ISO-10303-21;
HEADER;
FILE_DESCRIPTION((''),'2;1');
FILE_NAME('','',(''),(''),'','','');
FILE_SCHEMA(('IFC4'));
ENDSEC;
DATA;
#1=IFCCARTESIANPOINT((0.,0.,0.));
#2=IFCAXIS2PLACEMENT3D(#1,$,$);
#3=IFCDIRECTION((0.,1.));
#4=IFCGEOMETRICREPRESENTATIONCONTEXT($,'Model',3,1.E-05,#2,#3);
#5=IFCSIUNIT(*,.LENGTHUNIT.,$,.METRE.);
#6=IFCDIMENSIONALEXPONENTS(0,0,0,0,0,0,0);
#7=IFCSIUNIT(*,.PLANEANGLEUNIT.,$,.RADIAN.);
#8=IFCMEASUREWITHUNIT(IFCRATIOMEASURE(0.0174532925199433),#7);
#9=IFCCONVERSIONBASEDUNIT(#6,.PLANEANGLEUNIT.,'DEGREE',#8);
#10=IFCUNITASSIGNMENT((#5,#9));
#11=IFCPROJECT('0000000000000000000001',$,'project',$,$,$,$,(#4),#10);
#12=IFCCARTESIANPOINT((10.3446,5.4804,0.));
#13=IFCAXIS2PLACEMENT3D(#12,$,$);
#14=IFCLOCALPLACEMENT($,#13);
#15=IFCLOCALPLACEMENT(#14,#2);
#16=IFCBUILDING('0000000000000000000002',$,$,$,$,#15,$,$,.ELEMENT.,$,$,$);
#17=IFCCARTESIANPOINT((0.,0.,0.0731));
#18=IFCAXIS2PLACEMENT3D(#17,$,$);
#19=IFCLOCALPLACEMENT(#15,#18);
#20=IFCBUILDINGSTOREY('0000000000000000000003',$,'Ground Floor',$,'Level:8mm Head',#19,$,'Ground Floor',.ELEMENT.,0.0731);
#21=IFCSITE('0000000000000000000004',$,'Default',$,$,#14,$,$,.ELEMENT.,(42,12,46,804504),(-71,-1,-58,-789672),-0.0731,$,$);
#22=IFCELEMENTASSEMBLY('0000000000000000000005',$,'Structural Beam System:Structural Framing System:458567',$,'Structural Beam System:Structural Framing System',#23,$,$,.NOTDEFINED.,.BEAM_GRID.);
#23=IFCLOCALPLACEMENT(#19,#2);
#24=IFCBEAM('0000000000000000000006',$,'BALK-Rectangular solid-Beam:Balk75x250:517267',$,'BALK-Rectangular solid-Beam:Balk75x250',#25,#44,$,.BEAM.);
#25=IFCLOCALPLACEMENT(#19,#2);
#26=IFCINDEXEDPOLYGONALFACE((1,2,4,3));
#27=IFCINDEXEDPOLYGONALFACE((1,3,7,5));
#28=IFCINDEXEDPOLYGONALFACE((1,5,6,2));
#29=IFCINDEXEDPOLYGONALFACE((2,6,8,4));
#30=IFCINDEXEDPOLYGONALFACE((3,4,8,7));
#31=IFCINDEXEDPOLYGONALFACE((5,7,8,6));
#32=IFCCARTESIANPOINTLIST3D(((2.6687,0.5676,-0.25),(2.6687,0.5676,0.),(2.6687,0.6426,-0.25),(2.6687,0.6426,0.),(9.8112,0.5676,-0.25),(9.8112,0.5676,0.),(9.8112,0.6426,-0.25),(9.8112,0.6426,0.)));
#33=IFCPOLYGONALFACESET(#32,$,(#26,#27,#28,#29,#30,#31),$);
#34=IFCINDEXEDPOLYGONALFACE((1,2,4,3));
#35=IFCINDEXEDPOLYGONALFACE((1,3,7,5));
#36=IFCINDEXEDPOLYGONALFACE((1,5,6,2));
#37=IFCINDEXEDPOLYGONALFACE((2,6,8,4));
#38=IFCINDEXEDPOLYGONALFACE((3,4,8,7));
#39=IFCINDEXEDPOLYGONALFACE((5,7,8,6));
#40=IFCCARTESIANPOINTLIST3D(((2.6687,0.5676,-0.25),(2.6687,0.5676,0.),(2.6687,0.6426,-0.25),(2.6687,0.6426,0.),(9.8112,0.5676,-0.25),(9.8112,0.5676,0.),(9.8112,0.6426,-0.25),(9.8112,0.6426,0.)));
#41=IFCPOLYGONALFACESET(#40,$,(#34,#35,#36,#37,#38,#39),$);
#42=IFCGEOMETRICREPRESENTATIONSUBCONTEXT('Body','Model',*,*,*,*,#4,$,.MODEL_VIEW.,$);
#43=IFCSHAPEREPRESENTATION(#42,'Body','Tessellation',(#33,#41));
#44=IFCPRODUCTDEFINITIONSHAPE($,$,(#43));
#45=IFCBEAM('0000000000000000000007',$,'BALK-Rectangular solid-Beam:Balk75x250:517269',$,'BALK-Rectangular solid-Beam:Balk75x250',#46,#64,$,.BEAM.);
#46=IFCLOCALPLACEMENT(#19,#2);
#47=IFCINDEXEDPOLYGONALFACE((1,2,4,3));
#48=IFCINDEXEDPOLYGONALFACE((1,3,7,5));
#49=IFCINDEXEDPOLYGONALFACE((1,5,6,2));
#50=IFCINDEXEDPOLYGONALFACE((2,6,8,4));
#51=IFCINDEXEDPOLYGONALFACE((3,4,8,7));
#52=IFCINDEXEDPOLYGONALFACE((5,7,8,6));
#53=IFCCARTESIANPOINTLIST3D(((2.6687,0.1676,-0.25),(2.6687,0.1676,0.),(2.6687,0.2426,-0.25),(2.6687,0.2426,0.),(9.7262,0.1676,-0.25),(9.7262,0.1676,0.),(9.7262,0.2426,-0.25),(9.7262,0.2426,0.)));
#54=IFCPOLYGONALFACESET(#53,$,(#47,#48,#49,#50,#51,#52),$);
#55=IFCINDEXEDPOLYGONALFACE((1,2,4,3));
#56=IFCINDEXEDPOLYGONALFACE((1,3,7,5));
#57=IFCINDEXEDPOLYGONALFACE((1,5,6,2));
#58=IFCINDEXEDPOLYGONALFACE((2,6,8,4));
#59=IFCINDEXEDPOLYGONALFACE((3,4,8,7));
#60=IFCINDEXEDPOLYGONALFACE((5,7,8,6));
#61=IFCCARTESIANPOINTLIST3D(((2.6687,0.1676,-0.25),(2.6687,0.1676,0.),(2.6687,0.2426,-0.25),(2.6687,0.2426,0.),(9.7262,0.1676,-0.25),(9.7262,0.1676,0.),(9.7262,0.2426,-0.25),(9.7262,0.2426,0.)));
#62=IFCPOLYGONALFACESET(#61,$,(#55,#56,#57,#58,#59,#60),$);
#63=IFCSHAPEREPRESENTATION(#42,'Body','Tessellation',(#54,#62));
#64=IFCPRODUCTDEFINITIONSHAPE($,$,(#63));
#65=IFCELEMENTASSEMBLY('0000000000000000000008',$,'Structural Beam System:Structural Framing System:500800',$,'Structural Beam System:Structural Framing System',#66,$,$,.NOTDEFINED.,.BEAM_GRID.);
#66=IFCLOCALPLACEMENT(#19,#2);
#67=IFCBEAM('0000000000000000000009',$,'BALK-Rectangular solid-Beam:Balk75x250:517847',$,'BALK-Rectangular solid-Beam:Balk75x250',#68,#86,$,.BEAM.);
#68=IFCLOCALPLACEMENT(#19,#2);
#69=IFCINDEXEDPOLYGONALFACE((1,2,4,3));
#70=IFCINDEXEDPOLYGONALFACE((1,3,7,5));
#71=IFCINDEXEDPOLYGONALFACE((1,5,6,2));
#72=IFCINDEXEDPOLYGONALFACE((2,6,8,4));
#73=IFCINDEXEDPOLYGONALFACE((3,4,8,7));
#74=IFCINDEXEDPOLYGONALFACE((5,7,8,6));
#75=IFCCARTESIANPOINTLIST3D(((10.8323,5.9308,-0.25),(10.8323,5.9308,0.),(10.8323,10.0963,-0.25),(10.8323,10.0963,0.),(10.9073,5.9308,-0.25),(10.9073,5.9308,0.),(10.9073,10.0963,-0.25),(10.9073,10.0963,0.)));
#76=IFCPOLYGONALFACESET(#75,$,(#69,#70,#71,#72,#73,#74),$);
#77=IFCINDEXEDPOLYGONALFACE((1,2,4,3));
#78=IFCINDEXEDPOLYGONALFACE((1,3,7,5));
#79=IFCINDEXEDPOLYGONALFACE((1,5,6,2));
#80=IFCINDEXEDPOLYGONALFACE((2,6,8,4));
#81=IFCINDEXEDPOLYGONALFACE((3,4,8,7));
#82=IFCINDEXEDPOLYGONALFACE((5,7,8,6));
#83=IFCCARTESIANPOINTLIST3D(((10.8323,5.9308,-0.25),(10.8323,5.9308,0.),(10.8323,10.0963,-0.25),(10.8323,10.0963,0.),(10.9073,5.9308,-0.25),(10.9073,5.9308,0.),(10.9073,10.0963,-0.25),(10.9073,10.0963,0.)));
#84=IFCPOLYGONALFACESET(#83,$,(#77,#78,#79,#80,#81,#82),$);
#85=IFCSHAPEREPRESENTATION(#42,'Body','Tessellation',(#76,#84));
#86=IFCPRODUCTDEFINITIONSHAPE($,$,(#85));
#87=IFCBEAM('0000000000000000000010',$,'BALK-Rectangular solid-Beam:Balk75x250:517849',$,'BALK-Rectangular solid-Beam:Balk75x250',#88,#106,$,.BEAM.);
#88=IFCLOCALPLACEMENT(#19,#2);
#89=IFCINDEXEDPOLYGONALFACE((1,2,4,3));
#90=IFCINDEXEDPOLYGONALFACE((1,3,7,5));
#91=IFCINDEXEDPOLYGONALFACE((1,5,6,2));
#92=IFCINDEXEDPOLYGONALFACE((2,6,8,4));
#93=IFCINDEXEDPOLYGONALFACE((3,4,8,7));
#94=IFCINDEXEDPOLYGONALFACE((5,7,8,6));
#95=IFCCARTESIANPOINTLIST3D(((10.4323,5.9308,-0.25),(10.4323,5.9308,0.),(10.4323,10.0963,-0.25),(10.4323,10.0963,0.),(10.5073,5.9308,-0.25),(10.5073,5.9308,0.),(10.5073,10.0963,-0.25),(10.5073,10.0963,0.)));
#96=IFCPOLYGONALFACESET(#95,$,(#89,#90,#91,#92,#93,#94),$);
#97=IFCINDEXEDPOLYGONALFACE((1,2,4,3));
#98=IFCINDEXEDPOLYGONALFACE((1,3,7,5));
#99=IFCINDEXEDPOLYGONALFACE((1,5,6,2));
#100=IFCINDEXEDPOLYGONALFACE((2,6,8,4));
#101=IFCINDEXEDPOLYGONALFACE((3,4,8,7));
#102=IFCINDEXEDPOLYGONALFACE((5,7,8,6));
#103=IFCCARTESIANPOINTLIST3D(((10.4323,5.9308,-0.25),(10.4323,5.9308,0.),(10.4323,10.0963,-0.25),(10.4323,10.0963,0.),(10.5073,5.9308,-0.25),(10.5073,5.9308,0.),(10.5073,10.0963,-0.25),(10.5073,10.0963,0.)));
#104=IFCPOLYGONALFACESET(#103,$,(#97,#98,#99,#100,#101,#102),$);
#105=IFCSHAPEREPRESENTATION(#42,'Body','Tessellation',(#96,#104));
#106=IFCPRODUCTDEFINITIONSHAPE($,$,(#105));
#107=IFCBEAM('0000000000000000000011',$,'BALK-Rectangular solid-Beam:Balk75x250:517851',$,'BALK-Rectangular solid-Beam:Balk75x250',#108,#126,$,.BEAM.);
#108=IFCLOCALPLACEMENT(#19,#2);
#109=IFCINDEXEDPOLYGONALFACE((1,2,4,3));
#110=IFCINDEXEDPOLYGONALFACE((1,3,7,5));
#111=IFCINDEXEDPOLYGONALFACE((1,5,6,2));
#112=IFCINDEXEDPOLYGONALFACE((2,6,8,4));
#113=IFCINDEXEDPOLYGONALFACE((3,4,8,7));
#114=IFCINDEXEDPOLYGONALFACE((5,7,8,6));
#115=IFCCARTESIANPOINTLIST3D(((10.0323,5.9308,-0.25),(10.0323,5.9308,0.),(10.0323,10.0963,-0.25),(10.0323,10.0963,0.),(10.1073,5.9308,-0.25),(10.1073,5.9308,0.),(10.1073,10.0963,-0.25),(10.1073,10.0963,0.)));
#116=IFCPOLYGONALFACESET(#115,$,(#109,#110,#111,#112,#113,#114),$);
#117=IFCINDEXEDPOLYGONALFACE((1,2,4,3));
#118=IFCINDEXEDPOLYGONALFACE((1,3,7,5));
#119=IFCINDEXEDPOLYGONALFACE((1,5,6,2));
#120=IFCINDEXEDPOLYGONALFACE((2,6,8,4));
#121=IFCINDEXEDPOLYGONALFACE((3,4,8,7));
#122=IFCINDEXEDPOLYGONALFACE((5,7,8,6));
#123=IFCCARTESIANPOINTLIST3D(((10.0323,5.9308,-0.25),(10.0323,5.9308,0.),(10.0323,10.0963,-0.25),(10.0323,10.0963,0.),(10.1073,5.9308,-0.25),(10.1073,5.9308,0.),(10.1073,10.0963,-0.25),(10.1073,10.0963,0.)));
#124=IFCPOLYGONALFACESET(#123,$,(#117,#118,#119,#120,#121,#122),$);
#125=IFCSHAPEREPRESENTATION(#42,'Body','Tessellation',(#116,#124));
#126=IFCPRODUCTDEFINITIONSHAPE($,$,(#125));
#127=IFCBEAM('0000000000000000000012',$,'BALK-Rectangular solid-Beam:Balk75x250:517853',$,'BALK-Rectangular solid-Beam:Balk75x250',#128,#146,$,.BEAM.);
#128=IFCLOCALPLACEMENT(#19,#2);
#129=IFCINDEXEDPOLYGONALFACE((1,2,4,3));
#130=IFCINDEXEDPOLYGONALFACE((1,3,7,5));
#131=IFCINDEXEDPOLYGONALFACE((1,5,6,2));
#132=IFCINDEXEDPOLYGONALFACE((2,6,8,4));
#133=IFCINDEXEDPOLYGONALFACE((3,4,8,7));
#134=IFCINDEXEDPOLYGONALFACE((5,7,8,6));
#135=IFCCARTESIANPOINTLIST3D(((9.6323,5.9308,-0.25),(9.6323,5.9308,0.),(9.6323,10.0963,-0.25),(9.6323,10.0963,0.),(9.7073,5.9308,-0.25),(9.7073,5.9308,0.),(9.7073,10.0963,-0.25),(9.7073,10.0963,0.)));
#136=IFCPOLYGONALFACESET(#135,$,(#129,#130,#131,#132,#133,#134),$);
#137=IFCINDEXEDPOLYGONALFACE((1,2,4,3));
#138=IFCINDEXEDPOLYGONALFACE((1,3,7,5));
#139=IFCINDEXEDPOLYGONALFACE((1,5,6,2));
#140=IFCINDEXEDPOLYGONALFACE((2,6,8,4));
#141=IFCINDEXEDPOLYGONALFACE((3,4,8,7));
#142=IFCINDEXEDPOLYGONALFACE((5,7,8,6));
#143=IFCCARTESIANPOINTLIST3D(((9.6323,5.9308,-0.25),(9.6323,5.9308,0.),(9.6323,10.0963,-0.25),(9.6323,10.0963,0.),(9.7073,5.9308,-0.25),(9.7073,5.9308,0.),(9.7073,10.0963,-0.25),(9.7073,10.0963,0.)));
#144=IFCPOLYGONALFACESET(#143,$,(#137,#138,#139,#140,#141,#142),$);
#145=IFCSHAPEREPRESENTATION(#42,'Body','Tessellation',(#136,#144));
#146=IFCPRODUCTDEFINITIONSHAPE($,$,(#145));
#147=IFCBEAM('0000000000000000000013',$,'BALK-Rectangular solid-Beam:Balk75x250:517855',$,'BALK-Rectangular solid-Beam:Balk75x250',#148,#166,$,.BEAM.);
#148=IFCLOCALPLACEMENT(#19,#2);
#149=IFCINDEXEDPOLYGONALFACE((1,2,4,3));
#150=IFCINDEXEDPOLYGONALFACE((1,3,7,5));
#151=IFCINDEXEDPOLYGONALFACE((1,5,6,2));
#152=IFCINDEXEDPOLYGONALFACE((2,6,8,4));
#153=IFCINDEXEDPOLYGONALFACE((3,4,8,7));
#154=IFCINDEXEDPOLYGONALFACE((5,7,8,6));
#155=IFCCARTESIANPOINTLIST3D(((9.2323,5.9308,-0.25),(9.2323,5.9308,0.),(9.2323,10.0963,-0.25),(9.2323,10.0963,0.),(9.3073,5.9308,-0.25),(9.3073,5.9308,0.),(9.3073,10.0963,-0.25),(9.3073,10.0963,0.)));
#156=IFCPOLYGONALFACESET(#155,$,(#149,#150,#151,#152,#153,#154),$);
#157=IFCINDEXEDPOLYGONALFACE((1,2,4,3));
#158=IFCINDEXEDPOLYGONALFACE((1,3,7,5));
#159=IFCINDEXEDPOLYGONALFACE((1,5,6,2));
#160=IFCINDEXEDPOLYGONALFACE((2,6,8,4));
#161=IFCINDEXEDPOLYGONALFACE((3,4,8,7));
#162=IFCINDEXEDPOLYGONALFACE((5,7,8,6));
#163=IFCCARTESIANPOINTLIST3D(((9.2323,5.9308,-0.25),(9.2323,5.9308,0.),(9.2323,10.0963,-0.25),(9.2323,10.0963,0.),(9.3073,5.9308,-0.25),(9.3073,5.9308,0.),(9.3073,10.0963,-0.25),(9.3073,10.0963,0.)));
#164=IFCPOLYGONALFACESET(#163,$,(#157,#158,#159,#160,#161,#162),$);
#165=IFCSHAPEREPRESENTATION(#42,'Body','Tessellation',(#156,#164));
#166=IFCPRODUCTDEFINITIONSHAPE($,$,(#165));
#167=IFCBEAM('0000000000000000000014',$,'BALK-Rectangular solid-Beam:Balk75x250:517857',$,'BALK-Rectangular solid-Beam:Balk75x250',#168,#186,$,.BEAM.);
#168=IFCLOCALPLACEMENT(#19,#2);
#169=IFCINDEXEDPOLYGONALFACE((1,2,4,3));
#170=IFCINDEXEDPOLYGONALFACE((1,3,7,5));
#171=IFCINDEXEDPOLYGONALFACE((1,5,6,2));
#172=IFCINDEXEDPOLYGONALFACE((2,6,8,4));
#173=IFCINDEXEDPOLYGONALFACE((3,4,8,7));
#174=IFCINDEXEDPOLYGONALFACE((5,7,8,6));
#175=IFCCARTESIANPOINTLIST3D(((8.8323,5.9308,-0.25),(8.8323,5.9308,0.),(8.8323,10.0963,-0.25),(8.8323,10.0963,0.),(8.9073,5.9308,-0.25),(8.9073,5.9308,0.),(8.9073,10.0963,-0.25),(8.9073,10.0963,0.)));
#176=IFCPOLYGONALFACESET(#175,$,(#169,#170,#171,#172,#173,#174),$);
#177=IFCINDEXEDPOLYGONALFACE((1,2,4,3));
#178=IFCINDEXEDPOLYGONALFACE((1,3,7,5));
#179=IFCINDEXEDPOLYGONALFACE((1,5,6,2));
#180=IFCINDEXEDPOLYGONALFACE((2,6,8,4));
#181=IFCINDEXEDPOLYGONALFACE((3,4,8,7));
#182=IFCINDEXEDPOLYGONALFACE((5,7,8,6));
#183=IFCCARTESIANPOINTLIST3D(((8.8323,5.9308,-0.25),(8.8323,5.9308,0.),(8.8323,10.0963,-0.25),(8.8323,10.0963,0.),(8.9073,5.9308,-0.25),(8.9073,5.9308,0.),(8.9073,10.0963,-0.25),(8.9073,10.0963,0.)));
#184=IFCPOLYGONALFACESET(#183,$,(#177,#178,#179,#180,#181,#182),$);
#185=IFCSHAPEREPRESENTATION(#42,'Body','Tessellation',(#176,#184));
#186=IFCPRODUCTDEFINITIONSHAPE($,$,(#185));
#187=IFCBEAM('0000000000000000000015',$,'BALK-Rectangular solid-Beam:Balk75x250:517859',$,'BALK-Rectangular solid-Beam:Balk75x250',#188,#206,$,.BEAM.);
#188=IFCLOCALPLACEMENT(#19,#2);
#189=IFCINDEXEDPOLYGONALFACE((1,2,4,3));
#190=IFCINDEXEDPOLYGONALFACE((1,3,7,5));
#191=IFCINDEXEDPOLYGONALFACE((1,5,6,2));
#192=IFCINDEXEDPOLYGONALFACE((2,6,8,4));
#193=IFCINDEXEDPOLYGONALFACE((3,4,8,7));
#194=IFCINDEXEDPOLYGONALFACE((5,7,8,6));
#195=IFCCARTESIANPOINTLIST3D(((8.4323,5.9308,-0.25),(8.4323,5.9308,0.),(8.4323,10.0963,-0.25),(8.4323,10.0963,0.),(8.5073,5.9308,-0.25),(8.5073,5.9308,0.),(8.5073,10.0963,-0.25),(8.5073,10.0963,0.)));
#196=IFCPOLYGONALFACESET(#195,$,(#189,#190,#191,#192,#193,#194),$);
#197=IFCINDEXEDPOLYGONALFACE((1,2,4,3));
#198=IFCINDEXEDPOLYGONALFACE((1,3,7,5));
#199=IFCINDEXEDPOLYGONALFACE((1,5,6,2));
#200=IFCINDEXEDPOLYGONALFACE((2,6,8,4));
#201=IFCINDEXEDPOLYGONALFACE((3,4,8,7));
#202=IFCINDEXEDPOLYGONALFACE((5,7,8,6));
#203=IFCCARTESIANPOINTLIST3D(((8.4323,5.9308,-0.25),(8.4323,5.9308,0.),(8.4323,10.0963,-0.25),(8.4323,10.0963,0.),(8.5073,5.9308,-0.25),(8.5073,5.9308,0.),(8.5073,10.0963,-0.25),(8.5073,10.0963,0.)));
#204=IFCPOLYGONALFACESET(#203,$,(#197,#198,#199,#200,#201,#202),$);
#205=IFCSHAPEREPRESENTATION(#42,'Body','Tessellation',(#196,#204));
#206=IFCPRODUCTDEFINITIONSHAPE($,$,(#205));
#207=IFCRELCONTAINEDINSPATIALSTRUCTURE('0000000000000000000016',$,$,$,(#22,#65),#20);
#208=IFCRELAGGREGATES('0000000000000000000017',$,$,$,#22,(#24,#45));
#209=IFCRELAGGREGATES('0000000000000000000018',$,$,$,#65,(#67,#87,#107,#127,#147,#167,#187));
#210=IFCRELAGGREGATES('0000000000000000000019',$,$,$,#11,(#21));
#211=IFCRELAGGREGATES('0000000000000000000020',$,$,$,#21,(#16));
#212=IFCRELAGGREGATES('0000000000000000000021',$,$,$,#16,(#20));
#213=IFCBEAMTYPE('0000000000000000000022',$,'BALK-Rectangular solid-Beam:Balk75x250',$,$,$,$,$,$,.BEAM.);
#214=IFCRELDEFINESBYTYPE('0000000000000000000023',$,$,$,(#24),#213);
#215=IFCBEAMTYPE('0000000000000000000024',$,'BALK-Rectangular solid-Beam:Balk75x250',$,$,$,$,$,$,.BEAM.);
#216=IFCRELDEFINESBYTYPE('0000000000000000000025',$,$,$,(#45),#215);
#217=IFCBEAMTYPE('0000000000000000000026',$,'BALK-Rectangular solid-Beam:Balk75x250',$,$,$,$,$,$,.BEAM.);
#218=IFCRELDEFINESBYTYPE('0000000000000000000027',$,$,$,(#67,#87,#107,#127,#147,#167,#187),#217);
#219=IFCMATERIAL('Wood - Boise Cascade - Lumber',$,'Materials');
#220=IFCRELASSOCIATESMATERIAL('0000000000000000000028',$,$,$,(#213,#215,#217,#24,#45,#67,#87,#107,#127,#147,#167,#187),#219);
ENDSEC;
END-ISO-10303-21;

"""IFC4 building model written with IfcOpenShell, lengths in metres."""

from ifc_helpers import new_model, entity, si_unit, converted_unit, direction, frame, frame_2d, origin, origin_2d_with_axis, place, context, subcontext, project, spatial, rectangle, extrude, source, transform, mapped, material, material_profile, profile_set, profile_usage, type_object, type_shapes, element, aggregate, save


model = new_model("IFC4")

# Units and contexts
model_context = context("Model", 3, precision=1e-05, world=origin(), true_north=direction((0.0, 1.0)))
body_context = subcontext(model_context, "Body", "Model", "MODEL_VIEW")
ifc_project = project(units=[si_unit("LENGTHUNIT", "METRE"), converted_unit("PLANEANGLEUNIT", "DEGREE", entity("IfcRatioMeasure", 0.0174532925199433), si_unit("PLANEANGLEUNIT", "RADIAN"), dimensions=[0, 0, 0, 0, 0, 0, 0])], contexts=[model_context])

# Site, building, storey
site_placement = place(None, frame((10.3446, 5.4804, 0.0)))
site = spatial("IfcSite", under=ifc_project, at=site_placement, Name="Default", CompositionType="ELEMENT", RefLatitude=(42, 12, 46, 804504), RefLongitude=(-71, -1, -58, -789672), RefElevation=-0.0731)
building_placement = place(site_placement, origin())
building = spatial("IfcBuilding", under=site, at=building_placement, CompositionType="ELEMENT")
storey_placement = place(building_placement, frame((0.0, 0.0, 0.0731)))
storey = spatial("IfcBuildingStorey", under=building, at=storey_placement, Name="Ground Floor", ObjectType="Level:8mm Head", LongName="Ground Floor", CompositionType="ELEMENT", Elevation=0.0731)

# Element assemblies, beams
assembly_1_placement = place(storey_placement, origin())
assembly_1 = element("IfcElementAssembly", 1, at=assembly_1_placement, inside=storey, Name="Structural Beam System:Structural Framing System:458567", ObjectType="Structural Beam System:Structural Framing System", AssemblyPlace="NOTDEFINED", PredefinedType="BEAM_GRID")
ifc_material_1 = material(Name="Wood - Boise Cascade - Lumber", Category="Materials")
ifc_material_profile = material_profile(ifc_material_1, rectangle(XDim=0.25, YDim=0.075, at=frame_2d((0.0, 0.0), x_axis=(1.0, 0.0))), Name="Balk75x250")
ifc_profile_set = profile_set([ifc_material_profile], Name="Balk75x250")
ifc_profile_usage_1 = profile_usage(ifc_profile_set, cardinal=8)
beam_type_1 = type_object("IfcBeamType", Name="BALK-Rectangular solid-Beam:Balk75x250", PredefinedType="BEAM", material=ifc_profile_set)
shared_shape_1 = source(origin(), body_context, "Body", "SweptSolid", [
    extrude(rectangle(XDim=0.25, YDim=0.075, at=origin_2d_with_axis()), frame((-3.5283, 0.0, 0.0), z_axis=(1.0, 0.0, 0.0), x_axis=(0.0, 0.0, -1.0)), (0.0, 0.0, 1.0), 7.1426),
    extrude(rectangle(XDim=0.25, YDim=0.075, at=origin_2d_with_axis()), frame((-3.5283, 0.0, 0.0), z_axis=(1.0, 0.0, 0.0), x_axis=(0.0, 0.0, -1.0)), (0.0, 0.0, 1.0), 7.1426),
])
type_shapes(beam_type_1, [shared_shape_1])
beam_1_placement = place(assembly_1_placement, frame((6.197, 0.6051, -0.125)))
beam_1 = element("IfcBeam", 2, at=beam_1_placement, type_object=beam_type_1, material=ifc_profile_usage_1, Name="BALK-Rectangular solid-Beam:Balk75x250:517267", ObjectType="BALK-Rectangular solid-Beam:Balk75x250", PredefinedType="BEAM", context=body_context, shape_type="MappedRepresentation", body=[
    mapped(shared_shape_1, transform((0.0, 0.0, 0.0), scale=1.0)),
])
ifc_profile_usage_2 = profile_usage(ifc_profile_set, cardinal=8)
beam_type_2 = type_object("IfcBeamType", Name="BALK-Rectangular solid-Beam:Balk75x250", PredefinedType="BEAM", material=ifc_profile_set)
shared_shape_2 = source(origin(), body_context, "Body", "SweptSolid", [
    extrude(rectangle(XDim=0.25, YDim=0.075, at=origin_2d_with_axis()), frame((-3.4858, 0.0, 0.0), z_axis=(1.0, 0.0, 0.0), x_axis=(0.0, 0.0, -1.0)), (0.0, 0.0, 1.0), 7.0576),
    extrude(rectangle(XDim=0.25, YDim=0.075, at=origin_2d_with_axis()), frame((-3.4858, 0.0, 0.0), z_axis=(1.0, 0.0, 0.0), x_axis=(0.0, 0.0, -1.0)), (0.0, 0.0, 1.0), 7.0576),
])
type_shapes(beam_type_2, [shared_shape_2])
beam_2_placement = place(assembly_1_placement, frame((6.1545, 0.2051, -0.125)))
beam_2 = element("IfcBeam", 3, at=beam_2_placement, type_object=beam_type_2, material=ifc_profile_usage_2, Name="BALK-Rectangular solid-Beam:Balk75x250:517269", ObjectType="BALK-Rectangular solid-Beam:Balk75x250", PredefinedType="BEAM", context=body_context, shape_type="MappedRepresentation", body=[
    mapped(shared_shape_2, transform((0.0, 0.0, 0.0), scale=1.0)),
])
aggregate(assembly_1, [beam_1, beam_2])
assembly_2_placement = place(storey_placement, origin())
assembly_2 = element("IfcElementAssembly", 4, at=assembly_2_placement, inside=storey, Name="Structural Beam System:Structural Framing System:500800", ObjectType="Structural Beam System:Structural Framing System", AssemblyPlace="NOTDEFINED", PredefinedType="BEAM_GRID")
ifc_profile_usage_3 = profile_usage(ifc_profile_set, cardinal=8)
beam_type_3 = type_object("IfcBeamType", Name="BALK-Rectangular solid-Beam:Balk75x250", PredefinedType="BEAM", material=ifc_profile_set)
shared_shape_3 = source(origin(), body_context, "Body", "SweptSolid", [
    extrude(rectangle(XDim=0.25, YDim=0.075, at=origin_2d_with_axis()), frame((-2.089, 0.0, 0.0), z_axis=(1.0, 0.0, 0.0), x_axis=(0.0, 0.0, -1.0)), (0.0, 0.0, 1.0), 4.1655),
    extrude(rectangle(XDim=0.25, YDim=0.075, at=origin_2d_with_axis()), frame((-2.089, 0.0, 0.0), z_axis=(1.0, 0.0, 0.0), x_axis=(0.0, 0.0, -1.0)), (0.0, 0.0, 1.0), 4.1655),
])
type_shapes(beam_type_3, [shared_shape_3])
beam_3_placement = place(assembly_2_placement, frame((10.8698, 8.0073, -0.125), z_axis=(0.0, 0.0, 1.0), x_axis=(0.0, -1.0, 0.0)))
beam_3 = element("IfcBeam", 5, at=beam_3_placement, type_object=beam_type_3, material=ifc_profile_usage_3, Name="BALK-Rectangular solid-Beam:Balk75x250:517847", ObjectType="BALK-Rectangular solid-Beam:Balk75x250", PredefinedType="BEAM", context=body_context, shape_type="MappedRepresentation", body=[
    mapped(shared_shape_3, transform((0.0, 0.0, 0.0), scale=1.0)),
])
ifc_profile_usage_4 = profile_usage(ifc_profile_set, cardinal=8)
beam_4_placement = place(assembly_2_placement, frame((10.4698, 8.0073, -0.125), z_axis=(0.0, 0.0, 1.0), x_axis=(0.0, -1.0, 0.0)))
beam_4 = element("IfcBeam", 6, at=beam_4_placement, type_object=beam_type_3, material=ifc_profile_usage_4, Name="BALK-Rectangular solid-Beam:Balk75x250:517849", ObjectType="BALK-Rectangular solid-Beam:Balk75x250", PredefinedType="BEAM", context=body_context, shape_type="MappedRepresentation", body=[
    mapped(shared_shape_3, transform((0.0, 0.0, 0.0), scale=1.0)),
])
ifc_profile_usage_5 = profile_usage(ifc_profile_set, cardinal=8)
beam_5_placement = place(assembly_2_placement, frame((10.0698, 8.0073, -0.125), z_axis=(0.0, 0.0, 1.0), x_axis=(0.0, -1.0, 0.0)))
beam_5 = element("IfcBeam", 7, at=beam_5_placement, type_object=beam_type_3, material=ifc_profile_usage_5, Name="BALK-Rectangular solid-Beam:Balk75x250:517851", ObjectType="BALK-Rectangular solid-Beam:Balk75x250", PredefinedType="BEAM", context=body_context, shape_type="MappedRepresentation", body=[
    mapped(shared_shape_3, transform((0.0, 0.0, 0.0), scale=1.0)),
])
ifc_profile_usage_6 = profile_usage(ifc_profile_set, cardinal=8)
beam_6_placement = place(assembly_2_placement, frame((9.6698, 8.0073, -0.125), z_axis=(0.0, 0.0, 1.0), x_axis=(0.0, -1.0, 0.0)))
beam_6 = element("IfcBeam", 8, at=beam_6_placement, type_object=beam_type_3, material=ifc_profile_usage_6, Name="BALK-Rectangular solid-Beam:Balk75x250:517853", ObjectType="BALK-Rectangular solid-Beam:Balk75x250", PredefinedType="BEAM", context=body_context, shape_type="MappedRepresentation", body=[
    mapped(shared_shape_3, transform((0.0, 0.0, 0.0), scale=1.0)),
])
ifc_profile_usage_7 = profile_usage(ifc_profile_set, cardinal=8)
beam_7_placement = place(assembly_2_placement, frame((9.2698, 8.0073, -0.125), z_axis=(0.0, 0.0, 1.0), x_axis=(0.0, -1.0, 0.0)))
beam_7 = element("IfcBeam", 9, at=beam_7_placement, type_object=beam_type_3, material=ifc_profile_usage_7, Name="BALK-Rectangular solid-Beam:Balk75x250:517855", ObjectType="BALK-Rectangular solid-Beam:Balk75x250", PredefinedType="BEAM", context=body_context, shape_type="MappedRepresentation", body=[
    mapped(shared_shape_3, transform((0.0, 0.0, 0.0), scale=1.0)),
])
ifc_profile_usage_8 = profile_usage(ifc_profile_set, cardinal=8)
beam_8_placement = place(assembly_2_placement, frame((8.8698, 8.0073, -0.125), z_axis=(0.0, 0.0, 1.0), x_axis=(0.0, -1.0, 0.0)))
beam_8 = element("IfcBeam", 10, at=beam_8_placement, type_object=beam_type_3, material=ifc_profile_usage_8, Name="BALK-Rectangular solid-Beam:Balk75x250:517857", ObjectType="BALK-Rectangular solid-Beam:Balk75x250", PredefinedType="BEAM", context=body_context, shape_type="MappedRepresentation", body=[
    mapped(shared_shape_3, transform((0.0, 0.0, 0.0), scale=1.0)),
])
ifc_profile_usage_9 = profile_usage(ifc_profile_set, cardinal=8)
beam_9_placement = place(assembly_2_placement, frame((8.4698, 8.0073, -0.125), z_axis=(0.0, 0.0, 1.0), x_axis=(0.0, -1.0, 0.0)))
beam_9 = element("IfcBeam", 11, at=beam_9_placement, type_object=beam_type_3, material=ifc_profile_usage_9, Name="BALK-Rectangular solid-Beam:Balk75x250:517859", ObjectType="BALK-Rectangular solid-Beam:Balk75x250", PredefinedType="BEAM", context=body_context, shape_type="MappedRepresentation", body=[
    mapped(shared_shape_3, transform((0.0, 0.0, 0.0), scale=1.0)),
])
aggregate(assembly_2, [beam_3, beam_4, beam_5, beam_6, beam_7, beam_8, beam_9])

save(model, "model.ifc")
